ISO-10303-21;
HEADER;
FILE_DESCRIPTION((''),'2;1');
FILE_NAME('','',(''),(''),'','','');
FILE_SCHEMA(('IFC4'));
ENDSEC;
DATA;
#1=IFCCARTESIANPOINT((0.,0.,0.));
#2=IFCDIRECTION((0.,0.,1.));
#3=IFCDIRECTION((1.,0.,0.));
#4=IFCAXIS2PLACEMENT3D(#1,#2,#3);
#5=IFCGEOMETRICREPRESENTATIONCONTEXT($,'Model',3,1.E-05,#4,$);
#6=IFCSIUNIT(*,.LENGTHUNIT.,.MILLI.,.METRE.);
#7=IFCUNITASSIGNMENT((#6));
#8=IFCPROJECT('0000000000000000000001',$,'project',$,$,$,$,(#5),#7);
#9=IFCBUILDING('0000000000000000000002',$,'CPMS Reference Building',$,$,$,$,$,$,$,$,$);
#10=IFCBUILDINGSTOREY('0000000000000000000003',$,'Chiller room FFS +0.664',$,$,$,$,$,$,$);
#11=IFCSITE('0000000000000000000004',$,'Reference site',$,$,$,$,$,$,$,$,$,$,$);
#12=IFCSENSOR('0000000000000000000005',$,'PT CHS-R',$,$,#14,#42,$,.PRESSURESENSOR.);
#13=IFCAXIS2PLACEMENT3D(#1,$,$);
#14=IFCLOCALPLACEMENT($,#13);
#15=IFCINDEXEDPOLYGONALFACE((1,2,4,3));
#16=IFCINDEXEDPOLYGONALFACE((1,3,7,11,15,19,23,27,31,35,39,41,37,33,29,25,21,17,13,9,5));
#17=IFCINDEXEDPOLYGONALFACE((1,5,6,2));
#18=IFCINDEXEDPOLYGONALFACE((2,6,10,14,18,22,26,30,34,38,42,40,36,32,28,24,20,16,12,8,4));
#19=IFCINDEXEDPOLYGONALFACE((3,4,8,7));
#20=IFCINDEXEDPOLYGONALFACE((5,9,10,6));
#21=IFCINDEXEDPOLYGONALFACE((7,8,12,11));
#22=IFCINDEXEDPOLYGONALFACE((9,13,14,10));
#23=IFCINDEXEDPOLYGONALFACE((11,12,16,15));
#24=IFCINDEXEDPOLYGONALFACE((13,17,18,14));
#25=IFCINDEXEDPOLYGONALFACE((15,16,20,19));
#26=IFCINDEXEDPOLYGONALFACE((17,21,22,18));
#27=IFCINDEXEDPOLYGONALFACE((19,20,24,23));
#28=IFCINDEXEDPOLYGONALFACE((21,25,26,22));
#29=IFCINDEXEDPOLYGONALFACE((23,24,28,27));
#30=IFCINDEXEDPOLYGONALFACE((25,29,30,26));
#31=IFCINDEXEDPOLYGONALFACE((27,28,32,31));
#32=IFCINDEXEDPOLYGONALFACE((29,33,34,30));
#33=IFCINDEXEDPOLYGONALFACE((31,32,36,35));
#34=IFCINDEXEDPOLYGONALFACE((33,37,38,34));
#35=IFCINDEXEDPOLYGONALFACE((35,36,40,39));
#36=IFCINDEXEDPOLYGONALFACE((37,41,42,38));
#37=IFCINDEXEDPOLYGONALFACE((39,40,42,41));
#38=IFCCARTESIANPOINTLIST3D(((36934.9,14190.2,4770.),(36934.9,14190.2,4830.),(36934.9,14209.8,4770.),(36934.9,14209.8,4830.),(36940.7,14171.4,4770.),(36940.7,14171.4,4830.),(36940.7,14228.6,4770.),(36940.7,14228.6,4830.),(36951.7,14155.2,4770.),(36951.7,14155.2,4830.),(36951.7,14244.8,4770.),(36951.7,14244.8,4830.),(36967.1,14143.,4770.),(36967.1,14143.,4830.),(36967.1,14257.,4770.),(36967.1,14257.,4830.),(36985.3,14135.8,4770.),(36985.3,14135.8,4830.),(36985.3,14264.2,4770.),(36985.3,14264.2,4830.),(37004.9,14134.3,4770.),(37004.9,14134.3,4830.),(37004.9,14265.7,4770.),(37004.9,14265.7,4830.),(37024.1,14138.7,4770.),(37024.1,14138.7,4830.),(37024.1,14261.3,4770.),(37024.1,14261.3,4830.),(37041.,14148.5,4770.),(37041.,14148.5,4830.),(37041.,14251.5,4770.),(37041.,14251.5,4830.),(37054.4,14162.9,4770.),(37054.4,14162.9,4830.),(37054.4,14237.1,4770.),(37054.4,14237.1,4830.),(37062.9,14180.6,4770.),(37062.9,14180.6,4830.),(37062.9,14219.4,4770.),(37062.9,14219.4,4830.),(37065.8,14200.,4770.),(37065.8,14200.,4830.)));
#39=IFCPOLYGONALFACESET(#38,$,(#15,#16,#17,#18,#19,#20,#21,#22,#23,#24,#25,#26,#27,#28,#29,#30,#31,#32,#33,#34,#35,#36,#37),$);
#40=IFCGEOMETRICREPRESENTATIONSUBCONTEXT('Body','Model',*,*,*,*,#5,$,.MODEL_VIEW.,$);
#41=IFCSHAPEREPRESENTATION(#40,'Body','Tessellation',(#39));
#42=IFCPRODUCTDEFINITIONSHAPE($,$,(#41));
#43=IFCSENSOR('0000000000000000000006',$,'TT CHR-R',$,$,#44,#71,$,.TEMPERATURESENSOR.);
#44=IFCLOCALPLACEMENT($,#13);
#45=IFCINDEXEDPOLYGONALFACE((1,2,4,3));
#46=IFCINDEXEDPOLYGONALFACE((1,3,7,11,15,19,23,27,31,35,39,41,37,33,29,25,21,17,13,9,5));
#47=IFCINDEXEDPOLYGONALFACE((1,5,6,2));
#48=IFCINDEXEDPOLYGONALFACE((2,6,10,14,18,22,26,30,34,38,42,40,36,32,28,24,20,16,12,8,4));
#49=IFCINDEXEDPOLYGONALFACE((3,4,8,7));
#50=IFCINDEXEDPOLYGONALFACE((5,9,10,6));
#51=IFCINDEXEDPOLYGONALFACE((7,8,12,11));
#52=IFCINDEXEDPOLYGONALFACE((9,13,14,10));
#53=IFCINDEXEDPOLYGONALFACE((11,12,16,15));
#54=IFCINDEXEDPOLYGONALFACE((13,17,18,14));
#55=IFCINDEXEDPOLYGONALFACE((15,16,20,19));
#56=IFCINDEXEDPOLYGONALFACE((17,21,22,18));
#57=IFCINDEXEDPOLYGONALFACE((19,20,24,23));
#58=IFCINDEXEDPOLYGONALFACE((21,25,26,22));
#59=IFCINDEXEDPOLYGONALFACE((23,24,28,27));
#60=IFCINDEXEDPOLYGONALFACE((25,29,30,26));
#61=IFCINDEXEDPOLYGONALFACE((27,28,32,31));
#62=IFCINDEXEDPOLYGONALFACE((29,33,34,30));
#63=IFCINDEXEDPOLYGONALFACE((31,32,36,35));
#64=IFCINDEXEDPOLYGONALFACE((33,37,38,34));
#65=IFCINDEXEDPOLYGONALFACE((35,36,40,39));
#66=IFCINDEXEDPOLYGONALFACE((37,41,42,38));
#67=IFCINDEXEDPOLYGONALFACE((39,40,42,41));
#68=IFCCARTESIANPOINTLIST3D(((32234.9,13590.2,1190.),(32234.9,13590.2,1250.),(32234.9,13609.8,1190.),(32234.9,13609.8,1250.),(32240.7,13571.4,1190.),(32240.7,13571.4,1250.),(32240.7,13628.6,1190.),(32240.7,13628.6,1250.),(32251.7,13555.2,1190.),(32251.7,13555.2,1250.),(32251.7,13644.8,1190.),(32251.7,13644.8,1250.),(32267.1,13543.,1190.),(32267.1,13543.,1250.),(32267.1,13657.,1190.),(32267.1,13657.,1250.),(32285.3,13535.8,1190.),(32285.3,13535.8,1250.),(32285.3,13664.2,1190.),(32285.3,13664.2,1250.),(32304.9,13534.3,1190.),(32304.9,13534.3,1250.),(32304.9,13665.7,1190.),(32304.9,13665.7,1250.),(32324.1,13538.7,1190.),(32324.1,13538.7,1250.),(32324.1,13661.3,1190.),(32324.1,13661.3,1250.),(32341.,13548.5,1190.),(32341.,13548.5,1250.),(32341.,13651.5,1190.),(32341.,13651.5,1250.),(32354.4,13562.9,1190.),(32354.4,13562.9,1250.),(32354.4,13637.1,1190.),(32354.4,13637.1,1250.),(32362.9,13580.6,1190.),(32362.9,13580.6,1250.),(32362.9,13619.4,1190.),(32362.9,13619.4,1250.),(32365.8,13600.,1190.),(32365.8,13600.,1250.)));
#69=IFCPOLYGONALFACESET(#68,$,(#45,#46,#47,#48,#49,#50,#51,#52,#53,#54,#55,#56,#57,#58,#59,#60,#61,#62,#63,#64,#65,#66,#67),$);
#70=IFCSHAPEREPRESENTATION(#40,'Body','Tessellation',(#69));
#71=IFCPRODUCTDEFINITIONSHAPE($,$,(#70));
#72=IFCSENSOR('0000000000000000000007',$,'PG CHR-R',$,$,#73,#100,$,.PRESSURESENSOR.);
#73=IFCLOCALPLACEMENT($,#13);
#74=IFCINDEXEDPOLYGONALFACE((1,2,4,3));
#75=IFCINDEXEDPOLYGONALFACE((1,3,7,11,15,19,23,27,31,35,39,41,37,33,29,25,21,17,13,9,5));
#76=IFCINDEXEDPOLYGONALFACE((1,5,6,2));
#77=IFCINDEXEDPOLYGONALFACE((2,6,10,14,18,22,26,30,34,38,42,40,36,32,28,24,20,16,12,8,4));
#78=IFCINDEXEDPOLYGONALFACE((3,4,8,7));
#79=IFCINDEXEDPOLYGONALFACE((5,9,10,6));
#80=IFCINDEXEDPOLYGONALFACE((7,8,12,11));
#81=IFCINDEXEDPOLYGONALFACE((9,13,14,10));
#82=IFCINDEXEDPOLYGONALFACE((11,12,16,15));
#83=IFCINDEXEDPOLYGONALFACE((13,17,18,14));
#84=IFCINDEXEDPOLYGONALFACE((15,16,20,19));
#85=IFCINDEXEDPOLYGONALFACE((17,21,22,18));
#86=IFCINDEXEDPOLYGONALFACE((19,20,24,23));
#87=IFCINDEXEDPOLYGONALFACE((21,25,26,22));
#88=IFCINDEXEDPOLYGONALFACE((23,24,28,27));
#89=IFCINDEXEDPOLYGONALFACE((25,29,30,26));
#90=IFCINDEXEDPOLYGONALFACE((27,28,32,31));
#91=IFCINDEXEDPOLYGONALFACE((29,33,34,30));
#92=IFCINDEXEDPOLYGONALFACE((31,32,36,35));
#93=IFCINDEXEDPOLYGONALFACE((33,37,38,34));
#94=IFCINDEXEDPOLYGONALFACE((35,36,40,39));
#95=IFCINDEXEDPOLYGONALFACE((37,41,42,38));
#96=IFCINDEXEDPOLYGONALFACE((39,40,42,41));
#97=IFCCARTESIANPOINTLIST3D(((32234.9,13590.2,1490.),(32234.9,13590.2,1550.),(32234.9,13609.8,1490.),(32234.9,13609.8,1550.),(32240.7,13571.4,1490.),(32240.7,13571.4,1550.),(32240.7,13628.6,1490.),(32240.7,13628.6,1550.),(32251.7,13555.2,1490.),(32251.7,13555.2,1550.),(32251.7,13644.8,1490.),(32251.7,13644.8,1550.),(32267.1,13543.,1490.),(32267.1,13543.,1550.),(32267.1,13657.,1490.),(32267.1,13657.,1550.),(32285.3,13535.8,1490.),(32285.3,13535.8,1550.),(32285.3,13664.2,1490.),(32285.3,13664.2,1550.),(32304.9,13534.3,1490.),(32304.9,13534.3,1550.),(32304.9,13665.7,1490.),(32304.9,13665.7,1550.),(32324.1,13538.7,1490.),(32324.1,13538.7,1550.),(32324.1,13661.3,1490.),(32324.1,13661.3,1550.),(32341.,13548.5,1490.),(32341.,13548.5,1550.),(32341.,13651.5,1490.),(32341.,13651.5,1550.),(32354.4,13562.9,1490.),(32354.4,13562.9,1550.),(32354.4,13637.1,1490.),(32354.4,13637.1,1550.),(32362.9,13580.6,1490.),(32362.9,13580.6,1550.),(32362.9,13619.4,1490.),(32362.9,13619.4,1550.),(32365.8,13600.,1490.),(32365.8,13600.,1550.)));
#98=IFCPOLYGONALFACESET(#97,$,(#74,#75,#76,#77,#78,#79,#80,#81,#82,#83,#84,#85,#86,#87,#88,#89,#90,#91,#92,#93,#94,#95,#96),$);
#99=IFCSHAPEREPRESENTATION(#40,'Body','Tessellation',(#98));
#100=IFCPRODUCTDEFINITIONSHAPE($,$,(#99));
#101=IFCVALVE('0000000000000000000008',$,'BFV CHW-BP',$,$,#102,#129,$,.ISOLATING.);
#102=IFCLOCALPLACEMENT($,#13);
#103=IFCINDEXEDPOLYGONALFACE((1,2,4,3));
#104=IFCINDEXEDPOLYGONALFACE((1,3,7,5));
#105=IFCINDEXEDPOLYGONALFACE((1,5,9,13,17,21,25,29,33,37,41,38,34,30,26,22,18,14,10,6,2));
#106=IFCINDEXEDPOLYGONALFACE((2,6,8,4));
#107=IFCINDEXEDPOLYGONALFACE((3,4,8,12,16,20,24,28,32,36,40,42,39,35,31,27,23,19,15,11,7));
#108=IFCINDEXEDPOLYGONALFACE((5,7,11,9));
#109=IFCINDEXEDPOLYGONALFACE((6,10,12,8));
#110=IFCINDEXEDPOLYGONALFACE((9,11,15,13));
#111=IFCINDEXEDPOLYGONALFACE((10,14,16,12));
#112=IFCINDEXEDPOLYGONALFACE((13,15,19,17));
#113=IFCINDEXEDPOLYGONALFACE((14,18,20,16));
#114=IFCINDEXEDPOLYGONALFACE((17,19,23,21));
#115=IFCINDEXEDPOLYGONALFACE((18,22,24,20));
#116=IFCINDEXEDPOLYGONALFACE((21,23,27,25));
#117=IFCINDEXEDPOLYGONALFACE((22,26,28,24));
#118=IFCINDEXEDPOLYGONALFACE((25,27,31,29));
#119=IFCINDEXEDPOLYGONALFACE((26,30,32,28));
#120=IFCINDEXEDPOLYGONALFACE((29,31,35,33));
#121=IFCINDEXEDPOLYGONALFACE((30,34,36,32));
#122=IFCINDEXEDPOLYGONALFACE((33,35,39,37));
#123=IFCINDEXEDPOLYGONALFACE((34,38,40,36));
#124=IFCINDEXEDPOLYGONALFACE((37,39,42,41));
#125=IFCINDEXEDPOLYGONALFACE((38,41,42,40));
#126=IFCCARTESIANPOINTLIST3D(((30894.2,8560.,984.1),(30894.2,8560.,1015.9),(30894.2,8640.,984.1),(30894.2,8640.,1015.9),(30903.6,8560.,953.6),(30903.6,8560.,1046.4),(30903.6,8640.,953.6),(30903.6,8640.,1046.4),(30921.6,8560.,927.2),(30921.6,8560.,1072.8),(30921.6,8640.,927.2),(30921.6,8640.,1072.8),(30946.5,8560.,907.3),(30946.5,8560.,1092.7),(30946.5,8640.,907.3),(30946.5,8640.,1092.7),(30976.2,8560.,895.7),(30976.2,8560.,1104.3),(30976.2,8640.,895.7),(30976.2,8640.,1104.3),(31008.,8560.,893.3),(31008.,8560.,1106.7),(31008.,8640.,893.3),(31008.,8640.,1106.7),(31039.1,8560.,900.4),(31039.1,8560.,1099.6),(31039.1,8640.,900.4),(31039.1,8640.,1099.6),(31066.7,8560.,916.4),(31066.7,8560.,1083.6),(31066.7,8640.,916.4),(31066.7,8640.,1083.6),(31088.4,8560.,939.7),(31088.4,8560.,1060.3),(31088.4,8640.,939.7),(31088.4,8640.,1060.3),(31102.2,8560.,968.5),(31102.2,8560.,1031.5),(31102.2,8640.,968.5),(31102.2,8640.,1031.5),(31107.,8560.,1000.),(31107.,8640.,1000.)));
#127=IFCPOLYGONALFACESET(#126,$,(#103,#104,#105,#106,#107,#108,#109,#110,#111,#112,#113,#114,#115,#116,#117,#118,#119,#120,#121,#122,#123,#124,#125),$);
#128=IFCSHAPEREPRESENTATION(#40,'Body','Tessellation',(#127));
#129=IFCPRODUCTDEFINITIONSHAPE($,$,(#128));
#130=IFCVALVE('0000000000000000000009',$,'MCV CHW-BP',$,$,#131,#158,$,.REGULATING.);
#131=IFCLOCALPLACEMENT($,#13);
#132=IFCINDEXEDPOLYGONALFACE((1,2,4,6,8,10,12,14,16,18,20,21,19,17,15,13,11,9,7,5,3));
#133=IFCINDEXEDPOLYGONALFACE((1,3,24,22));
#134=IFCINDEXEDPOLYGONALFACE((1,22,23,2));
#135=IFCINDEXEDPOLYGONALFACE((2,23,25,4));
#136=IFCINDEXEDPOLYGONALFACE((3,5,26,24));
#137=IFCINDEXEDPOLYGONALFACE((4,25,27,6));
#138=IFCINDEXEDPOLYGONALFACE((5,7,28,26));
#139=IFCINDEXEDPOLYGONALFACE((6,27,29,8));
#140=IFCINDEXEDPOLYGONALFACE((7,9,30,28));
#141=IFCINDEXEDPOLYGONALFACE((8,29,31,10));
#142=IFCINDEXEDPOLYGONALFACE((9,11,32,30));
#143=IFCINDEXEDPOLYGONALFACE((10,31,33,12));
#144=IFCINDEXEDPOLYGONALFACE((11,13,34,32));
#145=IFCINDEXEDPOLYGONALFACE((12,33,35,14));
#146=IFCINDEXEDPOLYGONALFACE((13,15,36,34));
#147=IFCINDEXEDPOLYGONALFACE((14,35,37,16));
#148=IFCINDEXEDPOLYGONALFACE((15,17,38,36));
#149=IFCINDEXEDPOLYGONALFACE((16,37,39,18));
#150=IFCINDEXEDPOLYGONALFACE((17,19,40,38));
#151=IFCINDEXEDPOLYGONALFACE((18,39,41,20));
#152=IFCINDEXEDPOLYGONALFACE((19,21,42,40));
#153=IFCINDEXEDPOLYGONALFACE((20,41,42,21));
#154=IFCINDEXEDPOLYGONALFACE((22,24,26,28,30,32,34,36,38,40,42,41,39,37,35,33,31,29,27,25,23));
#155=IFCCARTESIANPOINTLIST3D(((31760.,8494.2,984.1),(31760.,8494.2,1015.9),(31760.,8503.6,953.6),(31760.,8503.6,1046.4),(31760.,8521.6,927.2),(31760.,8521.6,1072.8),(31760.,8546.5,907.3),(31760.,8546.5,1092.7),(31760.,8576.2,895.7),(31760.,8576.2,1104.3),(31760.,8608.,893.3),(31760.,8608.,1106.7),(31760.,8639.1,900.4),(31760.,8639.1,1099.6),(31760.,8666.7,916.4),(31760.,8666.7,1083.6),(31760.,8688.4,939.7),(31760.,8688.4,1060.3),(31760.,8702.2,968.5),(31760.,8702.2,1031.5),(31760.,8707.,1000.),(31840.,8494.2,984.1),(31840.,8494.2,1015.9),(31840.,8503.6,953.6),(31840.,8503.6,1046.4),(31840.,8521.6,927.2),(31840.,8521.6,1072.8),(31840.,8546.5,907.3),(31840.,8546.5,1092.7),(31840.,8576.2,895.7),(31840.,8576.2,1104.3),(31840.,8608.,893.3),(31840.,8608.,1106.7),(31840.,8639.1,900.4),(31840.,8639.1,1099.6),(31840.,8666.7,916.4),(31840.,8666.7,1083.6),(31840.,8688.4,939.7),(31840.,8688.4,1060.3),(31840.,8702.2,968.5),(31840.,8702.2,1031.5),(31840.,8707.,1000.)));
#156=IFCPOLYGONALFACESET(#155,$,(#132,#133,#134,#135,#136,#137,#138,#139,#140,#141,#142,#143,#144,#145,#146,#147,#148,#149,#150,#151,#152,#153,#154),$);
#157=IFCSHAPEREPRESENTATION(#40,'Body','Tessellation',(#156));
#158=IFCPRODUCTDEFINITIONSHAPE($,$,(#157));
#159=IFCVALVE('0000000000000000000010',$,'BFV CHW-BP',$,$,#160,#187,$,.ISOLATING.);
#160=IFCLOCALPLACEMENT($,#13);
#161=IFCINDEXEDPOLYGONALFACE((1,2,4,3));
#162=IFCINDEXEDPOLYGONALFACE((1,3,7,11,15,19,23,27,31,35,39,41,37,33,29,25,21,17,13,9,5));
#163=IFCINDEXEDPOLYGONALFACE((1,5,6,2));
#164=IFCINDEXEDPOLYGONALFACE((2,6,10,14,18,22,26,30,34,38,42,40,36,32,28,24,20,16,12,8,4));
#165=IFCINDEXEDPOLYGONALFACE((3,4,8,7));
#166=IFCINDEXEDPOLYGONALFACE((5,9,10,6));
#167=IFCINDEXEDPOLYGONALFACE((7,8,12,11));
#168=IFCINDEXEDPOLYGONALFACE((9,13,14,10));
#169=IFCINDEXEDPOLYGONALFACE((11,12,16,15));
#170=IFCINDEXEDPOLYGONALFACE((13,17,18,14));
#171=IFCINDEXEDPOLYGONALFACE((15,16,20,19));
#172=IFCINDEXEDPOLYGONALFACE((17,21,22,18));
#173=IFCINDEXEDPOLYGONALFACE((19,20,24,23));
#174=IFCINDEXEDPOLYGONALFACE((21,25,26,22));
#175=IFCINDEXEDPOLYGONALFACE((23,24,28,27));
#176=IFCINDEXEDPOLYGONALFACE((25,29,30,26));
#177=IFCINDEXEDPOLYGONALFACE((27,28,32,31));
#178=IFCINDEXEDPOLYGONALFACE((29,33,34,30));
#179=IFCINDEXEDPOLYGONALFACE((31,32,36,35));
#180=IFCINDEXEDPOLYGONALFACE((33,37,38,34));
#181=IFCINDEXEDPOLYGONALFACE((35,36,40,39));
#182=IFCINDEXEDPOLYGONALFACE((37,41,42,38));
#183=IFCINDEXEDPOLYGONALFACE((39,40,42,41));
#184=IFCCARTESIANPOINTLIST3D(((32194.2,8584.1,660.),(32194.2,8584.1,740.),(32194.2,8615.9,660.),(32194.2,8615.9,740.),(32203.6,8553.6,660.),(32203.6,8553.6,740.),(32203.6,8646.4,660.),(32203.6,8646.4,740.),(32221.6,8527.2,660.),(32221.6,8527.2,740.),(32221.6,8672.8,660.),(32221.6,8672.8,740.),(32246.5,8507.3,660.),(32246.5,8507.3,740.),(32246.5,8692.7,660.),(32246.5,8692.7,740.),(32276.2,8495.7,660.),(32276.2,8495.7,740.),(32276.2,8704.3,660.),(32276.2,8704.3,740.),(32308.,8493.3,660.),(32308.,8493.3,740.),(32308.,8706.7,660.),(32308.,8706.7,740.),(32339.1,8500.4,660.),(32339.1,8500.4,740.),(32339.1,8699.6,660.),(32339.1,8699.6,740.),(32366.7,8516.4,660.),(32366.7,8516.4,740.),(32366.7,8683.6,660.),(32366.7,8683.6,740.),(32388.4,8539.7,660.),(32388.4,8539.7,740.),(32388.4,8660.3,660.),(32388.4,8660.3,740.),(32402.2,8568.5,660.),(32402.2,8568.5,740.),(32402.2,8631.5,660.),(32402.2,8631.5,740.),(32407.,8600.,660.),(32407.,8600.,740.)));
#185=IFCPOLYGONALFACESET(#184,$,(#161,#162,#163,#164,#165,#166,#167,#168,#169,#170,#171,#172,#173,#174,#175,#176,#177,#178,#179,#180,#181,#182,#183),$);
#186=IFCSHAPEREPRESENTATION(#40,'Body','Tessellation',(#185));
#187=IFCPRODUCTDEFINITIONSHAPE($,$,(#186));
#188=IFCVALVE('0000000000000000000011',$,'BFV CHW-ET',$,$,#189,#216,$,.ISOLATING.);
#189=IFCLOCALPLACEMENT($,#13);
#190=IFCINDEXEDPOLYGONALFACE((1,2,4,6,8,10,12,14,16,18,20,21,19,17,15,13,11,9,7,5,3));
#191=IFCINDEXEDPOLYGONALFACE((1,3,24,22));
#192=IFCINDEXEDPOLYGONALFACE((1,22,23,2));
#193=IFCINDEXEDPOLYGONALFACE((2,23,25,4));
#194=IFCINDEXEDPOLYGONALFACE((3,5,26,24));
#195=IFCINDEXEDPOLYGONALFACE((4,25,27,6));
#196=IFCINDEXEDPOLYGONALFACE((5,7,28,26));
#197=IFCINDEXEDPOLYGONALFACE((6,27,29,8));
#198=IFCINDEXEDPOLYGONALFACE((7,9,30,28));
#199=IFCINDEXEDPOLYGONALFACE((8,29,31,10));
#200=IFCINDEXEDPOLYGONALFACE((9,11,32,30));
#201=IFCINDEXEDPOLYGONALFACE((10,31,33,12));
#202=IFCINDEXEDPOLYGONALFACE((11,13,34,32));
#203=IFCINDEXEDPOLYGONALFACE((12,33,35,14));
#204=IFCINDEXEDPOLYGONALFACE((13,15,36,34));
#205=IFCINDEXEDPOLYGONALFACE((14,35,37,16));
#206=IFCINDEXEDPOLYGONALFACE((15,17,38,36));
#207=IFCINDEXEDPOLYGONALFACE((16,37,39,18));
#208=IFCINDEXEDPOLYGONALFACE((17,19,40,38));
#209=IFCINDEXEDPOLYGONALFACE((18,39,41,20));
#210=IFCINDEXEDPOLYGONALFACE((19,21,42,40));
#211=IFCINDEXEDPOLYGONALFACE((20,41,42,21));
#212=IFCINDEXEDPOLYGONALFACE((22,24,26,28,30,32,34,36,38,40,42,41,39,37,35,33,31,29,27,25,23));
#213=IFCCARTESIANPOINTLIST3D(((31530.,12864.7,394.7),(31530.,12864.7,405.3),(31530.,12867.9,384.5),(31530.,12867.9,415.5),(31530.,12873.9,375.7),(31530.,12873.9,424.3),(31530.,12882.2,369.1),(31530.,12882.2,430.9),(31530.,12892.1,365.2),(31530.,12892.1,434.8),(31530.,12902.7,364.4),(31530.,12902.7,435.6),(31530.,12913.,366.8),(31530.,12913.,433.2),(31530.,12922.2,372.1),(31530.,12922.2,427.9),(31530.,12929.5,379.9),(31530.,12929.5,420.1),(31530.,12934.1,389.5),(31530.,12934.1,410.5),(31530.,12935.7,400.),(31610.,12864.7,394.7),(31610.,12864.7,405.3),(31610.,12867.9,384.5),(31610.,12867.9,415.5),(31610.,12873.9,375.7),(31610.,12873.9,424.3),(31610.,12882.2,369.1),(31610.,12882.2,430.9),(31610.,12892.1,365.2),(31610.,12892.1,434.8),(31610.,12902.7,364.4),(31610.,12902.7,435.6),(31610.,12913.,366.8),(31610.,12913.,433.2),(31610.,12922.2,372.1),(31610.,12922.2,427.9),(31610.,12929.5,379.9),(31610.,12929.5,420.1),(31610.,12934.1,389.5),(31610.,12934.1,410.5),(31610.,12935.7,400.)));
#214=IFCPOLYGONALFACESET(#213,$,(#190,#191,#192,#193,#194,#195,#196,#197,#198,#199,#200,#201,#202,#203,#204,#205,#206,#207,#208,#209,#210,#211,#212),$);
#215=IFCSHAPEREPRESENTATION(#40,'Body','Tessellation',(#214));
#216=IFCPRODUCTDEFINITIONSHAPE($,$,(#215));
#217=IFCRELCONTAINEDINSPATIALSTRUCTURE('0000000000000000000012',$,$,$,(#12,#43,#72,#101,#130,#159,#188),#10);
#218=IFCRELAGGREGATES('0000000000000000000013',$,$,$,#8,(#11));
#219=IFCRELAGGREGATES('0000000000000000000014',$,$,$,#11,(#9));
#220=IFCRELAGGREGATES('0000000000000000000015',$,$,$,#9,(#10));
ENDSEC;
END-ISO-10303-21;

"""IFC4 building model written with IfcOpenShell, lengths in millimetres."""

from ifc_helpers import new_model, si_unit, frame, origin_with_axes, origin_2d, place, context, subcontext, project, spatial, circle_curve, outline, extrude, element, save


model = new_model("IFC4")

# Units and contexts
model_context = context("Model", 3, precision=1e-05, world=origin_with_axes())
body_context = subcontext(model_context, "Body", "Model", "MODEL_VIEW")
ifc_project = project(units=[si_unit("LENGTHUNIT", "METRE", prefix="MILLI")], contexts=[model_context])

# Site, building, storey
site = spatial("IfcSite", under=ifc_project, Name="Reference site")
building = spatial("IfcBuilding", under=site, Name="CPMS Reference Building")
storey = spatial("IfcBuildingStorey", under=building, Name="Chiller room FFS +0.664")

# Sensors
sensor_1_placement = place(None, origin_with_axes())
element("IfcSensor", 1, at=sensor_1_placement, inside=storey, Name="PT CHS-R", PredefinedType="PRESSURESENSOR", context=body_context, shape_type="SweptSolid", body=[
    extrude(outline(circle_curve(origin_2d(), 65.8)), frame((37000.0, 14200.0, 4770.0), z_axis=(0.0, 0.0, 1.0), x_axis=(1.0, 0.0, 0.0)), (0.0, 0.0, 1.0), 60.0),
])
sensor_2_placement = place(None, origin_with_axes())
element("IfcSensor", 2, at=sensor_2_placement, inside=storey, Name="TT CHR-R", PredefinedType="TEMPERATURESENSOR", context=body_context, shape_type="SweptSolid", body=[
    extrude(outline(circle_curve(origin_2d(), 65.8)), frame((32300.0, 13600.0, 1250.0), z_axis=(0.0, 0.0, -1.0), x_axis=(1.0, 0.0, 0.0)), (0.0, 0.0, 1.0), 60.0),
])
sensor_3_placement = place(None, origin_with_axes())
element("IfcSensor", 3, at=sensor_3_placement, inside=storey, Name="PG CHR-R", PredefinedType="PRESSURESENSOR", context=body_context, shape_type="SweptSolid", body=[
    extrude(outline(circle_curve(origin_2d(), 65.8)), frame((32300.0, 13600.0, 1550.0), z_axis=(0.0, 0.0, -1.0), x_axis=(1.0, 0.0, 0.0)), (0.0, 0.0, 1.0), 60.0),
])

# Valves
valve_1_placement = place(None, origin_with_axes())
element("IfcValve", 4, at=valve_1_placement, inside=storey, Name="BFV CHW-BP", PredefinedType="ISOLATING", context=body_context, shape_type="SweptSolid", body=[
    extrude(outline(circle_curve(origin_2d(), 107.0)), frame((31000.0, 8560.0, 1000.0), z_axis=(0.0, 1.0, 0.0), x_axis=(1.0, 0.0, 0.0)), (0.0, 0.0, 1.0), 80.0),
])
valve_2_placement = place(None, origin_with_axes())
element("IfcValve", 5, at=valve_2_placement, inside=storey, Name="MCV CHW-BP", PredefinedType="REGULATING", context=body_context, shape_type="SweptSolid", body=[
    extrude(outline(circle_curve(origin_2d(), 107.0)), frame((31760.0, 8600.0, 1000.0), z_axis=(1.0, 0.0, 0.0), x_axis=(0.0, 1.0, 0.0)), (0.0, 0.0, 1.0), 80.0),
])
valve_3_placement = place(None, origin_with_axes())
element("IfcValve", 6, at=valve_3_placement, inside=storey, Name="BFV CHW-BP", PredefinedType="ISOLATING", context=body_context, shape_type="SweptSolid", body=[
    extrude(outline(circle_curve(origin_2d(), 107.0)), frame((32300.0, 8600.0, 740.0), z_axis=(0.0, 0.0, -1.0), x_axis=(1.0, 0.0, 0.0)), (0.0, 0.0, 1.0), 80.0),
])
valve_4_placement = place(None, origin_with_axes())
element("IfcValve", 7, at=valve_4_placement, inside=storey, Name="BFV CHW-ET", PredefinedType="ISOLATING", context=body_context, shape_type="SweptSolid", body=[
    extrude(outline(circle_curve(origin_2d(), 35.7)), frame((31530.0, 12900.0, 400.0), z_axis=(1.0, 0.0, 0.0), x_axis=(0.0, 1.0, 0.0)), (0.0, 0.0, 1.0), 80.0),
])

save(model, "model.ifc")
